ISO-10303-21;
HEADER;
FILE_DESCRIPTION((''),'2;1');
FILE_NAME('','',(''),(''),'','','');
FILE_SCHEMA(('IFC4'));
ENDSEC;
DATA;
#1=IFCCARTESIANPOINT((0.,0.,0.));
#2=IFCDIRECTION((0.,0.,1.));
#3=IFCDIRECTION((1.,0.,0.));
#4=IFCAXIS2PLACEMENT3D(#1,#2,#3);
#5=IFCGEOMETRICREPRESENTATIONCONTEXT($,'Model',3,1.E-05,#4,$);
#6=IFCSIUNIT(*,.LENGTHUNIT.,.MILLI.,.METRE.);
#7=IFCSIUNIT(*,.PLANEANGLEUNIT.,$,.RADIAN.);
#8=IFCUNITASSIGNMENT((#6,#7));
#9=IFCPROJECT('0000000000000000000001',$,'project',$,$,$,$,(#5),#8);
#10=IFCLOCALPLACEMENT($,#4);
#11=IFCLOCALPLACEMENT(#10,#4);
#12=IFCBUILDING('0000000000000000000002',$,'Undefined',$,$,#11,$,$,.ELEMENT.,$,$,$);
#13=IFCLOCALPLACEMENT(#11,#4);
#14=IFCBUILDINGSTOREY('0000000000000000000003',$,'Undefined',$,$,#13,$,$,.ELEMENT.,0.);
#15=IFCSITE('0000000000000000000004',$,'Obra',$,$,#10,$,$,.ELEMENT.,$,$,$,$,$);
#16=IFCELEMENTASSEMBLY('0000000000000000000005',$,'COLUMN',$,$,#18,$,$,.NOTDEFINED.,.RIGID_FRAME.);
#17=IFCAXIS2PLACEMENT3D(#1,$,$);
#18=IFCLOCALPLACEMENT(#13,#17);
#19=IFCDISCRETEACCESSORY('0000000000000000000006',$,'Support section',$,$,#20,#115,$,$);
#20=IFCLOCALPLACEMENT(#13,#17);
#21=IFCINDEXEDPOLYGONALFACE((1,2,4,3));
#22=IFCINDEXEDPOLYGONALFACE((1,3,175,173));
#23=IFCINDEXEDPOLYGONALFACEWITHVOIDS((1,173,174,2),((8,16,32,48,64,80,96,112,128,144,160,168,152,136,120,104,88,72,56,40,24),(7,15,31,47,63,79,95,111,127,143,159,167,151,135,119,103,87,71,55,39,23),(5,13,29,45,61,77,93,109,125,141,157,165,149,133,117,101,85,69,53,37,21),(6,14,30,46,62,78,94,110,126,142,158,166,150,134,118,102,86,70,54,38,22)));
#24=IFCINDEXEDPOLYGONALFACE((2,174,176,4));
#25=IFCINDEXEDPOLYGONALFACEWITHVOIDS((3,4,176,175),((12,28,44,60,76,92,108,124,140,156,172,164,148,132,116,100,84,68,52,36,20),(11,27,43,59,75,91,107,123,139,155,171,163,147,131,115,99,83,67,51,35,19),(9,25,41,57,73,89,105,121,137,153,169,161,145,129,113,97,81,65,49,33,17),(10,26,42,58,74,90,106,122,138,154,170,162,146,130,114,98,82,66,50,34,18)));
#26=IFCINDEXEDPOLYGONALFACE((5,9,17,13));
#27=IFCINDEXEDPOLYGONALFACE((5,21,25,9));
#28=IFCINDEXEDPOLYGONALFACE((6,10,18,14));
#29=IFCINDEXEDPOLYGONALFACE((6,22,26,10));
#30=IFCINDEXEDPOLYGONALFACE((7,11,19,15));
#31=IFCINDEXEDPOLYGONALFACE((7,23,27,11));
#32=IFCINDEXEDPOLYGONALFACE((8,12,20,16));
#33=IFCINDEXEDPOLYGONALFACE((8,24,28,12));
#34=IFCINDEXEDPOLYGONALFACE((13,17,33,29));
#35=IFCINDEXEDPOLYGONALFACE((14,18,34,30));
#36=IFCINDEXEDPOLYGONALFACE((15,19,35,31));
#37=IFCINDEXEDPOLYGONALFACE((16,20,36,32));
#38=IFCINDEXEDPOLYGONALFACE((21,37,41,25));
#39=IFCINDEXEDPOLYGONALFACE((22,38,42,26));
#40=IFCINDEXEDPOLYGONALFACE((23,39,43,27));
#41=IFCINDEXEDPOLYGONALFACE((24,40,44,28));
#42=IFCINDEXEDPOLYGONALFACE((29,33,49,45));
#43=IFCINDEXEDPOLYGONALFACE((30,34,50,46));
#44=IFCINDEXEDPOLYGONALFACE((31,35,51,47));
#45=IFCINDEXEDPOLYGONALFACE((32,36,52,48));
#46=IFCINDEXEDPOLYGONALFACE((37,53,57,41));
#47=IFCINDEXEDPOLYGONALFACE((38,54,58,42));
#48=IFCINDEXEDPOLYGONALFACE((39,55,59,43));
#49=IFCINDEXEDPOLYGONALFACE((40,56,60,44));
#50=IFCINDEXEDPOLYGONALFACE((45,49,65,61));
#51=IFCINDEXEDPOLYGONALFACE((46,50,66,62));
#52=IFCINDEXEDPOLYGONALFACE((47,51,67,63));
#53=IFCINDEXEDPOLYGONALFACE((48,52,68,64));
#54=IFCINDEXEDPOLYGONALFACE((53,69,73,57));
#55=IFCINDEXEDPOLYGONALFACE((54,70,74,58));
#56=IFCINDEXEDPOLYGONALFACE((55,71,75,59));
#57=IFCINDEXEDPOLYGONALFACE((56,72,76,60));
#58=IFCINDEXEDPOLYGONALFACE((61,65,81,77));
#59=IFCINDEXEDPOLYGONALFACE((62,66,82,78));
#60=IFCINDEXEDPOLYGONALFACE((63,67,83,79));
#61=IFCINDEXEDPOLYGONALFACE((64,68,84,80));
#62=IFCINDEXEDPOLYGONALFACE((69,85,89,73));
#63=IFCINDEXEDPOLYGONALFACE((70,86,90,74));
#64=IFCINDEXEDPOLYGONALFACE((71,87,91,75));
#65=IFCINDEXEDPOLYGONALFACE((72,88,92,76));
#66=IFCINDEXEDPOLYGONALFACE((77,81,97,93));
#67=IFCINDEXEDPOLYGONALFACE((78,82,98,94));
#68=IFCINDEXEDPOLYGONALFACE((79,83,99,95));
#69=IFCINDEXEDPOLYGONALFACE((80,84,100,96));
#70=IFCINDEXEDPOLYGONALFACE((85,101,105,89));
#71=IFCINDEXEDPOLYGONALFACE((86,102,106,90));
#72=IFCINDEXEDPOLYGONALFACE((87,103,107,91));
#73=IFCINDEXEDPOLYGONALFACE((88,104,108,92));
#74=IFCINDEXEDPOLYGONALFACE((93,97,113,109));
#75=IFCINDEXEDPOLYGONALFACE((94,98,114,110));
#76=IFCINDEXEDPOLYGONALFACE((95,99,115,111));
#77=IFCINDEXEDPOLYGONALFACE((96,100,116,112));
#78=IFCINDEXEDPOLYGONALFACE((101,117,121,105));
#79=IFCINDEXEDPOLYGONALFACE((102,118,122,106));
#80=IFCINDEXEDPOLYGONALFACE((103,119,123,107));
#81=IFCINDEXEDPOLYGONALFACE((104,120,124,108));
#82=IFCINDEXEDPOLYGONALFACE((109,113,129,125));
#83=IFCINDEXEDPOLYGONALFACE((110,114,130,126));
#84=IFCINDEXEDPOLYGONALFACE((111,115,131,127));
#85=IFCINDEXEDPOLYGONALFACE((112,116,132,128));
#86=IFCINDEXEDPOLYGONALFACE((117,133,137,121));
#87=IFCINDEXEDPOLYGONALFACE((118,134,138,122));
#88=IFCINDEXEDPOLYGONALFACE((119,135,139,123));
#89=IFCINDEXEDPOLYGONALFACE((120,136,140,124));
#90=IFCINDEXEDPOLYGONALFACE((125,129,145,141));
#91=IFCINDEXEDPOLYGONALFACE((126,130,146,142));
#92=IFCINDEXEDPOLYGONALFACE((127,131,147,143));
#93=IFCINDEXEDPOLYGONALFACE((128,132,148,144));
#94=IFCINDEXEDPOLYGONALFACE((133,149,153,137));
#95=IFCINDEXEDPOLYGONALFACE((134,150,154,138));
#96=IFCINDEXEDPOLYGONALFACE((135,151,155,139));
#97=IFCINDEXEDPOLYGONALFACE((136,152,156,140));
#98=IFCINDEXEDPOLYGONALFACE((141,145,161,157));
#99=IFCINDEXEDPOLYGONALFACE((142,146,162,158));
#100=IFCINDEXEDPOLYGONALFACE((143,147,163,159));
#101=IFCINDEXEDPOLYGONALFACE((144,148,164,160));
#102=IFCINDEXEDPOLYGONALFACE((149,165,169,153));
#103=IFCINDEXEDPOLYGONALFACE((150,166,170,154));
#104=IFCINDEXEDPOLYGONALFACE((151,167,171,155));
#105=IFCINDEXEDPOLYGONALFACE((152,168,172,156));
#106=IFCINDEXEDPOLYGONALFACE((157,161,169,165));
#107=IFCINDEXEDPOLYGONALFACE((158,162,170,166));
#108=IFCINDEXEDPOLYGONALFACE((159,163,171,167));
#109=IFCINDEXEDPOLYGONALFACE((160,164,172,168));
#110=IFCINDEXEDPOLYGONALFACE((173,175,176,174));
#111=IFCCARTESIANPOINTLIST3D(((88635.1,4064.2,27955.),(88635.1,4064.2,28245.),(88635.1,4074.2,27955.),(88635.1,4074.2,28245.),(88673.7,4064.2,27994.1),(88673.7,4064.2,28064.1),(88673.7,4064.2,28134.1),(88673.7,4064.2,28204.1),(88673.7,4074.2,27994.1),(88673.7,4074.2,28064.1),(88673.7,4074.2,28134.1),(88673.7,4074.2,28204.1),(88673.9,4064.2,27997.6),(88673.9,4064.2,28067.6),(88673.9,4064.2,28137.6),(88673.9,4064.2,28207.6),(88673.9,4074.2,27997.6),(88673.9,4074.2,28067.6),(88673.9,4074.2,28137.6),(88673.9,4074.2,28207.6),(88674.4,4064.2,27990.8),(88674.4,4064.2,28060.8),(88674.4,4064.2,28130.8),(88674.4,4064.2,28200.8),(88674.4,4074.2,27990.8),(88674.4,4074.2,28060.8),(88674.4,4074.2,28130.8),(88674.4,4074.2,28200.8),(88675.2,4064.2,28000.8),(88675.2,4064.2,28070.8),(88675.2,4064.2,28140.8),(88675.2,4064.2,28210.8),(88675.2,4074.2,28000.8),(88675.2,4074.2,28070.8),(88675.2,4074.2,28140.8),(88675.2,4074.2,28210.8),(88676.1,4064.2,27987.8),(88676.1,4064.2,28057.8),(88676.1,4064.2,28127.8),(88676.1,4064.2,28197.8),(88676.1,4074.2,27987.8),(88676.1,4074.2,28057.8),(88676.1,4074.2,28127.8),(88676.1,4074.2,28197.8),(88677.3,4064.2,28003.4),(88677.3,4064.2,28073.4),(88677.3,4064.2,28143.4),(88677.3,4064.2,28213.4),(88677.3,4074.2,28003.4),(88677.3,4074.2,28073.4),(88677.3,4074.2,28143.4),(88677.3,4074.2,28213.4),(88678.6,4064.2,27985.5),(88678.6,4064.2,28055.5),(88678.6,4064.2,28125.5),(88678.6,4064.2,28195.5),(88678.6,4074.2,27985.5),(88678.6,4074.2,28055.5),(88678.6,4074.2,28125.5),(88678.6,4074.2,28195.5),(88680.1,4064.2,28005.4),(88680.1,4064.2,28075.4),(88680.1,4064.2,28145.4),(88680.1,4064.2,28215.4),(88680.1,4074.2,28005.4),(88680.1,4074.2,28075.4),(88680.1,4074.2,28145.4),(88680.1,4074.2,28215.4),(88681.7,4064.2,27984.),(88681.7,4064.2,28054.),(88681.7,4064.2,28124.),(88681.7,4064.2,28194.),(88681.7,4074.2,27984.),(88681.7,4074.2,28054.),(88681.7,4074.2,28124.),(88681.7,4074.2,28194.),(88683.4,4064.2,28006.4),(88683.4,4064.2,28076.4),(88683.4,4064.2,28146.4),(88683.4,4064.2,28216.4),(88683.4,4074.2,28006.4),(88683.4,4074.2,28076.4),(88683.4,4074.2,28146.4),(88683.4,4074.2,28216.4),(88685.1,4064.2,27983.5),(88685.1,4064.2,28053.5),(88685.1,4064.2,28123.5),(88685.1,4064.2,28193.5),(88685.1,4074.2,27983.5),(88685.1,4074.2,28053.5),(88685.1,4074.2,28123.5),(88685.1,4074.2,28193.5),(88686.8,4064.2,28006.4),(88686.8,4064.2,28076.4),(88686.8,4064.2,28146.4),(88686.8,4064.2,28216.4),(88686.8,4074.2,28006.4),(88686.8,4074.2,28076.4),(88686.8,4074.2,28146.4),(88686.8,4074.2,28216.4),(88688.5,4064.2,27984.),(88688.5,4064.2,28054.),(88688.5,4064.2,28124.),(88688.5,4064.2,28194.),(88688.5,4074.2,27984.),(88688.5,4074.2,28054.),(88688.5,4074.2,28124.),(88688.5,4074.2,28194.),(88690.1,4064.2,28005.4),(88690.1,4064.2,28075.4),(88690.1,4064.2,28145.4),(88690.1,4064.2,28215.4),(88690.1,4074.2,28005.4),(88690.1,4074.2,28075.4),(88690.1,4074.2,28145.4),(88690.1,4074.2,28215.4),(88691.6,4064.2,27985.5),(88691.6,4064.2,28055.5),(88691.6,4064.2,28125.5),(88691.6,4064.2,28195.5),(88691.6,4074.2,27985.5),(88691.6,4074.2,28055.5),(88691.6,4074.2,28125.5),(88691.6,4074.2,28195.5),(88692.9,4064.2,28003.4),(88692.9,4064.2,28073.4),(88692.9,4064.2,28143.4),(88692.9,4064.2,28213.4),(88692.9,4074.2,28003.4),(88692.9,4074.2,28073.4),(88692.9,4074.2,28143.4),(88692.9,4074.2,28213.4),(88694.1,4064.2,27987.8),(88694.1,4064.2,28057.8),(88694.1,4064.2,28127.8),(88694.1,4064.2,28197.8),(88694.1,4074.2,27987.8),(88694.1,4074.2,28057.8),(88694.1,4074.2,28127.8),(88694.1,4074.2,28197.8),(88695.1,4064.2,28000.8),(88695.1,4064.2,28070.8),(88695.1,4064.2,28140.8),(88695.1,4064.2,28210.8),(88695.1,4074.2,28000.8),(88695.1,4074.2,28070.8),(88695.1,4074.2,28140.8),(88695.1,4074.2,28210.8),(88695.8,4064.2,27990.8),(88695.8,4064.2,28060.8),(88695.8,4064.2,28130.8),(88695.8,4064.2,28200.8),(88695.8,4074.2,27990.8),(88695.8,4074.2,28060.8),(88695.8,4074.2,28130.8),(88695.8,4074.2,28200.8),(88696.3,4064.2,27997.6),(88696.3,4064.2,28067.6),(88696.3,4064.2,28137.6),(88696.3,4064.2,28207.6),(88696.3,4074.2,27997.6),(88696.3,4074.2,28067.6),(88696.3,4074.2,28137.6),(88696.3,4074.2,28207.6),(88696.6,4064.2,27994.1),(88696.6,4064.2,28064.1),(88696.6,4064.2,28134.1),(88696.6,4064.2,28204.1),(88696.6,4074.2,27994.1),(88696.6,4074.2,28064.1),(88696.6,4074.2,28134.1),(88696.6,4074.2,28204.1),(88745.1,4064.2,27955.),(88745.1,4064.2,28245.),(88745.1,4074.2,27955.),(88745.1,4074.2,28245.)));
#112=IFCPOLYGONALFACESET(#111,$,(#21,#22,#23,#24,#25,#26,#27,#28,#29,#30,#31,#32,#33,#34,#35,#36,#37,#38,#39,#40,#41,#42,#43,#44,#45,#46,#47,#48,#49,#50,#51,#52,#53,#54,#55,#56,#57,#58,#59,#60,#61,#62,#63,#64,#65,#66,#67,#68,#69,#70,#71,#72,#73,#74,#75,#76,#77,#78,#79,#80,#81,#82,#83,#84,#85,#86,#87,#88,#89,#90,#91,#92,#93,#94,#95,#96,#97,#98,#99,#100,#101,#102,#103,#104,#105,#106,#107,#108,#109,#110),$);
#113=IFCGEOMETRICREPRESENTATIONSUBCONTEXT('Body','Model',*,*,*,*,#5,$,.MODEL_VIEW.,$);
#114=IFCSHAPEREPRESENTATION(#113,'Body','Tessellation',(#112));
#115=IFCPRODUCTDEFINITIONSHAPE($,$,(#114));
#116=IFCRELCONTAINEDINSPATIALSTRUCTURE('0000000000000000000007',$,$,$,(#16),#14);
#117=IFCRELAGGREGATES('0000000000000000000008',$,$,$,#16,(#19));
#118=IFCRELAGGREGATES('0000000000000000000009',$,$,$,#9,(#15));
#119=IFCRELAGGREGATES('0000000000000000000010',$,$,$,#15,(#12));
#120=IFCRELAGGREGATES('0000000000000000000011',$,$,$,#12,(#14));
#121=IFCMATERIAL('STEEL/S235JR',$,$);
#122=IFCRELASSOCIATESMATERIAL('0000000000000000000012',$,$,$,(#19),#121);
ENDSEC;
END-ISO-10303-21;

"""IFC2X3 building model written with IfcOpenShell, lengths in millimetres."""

from ifc_helpers import new_model, si_unit, frame, origin_with_axes, origin_2d_with_axis, place, context, subcontext, project, spatial, rectangle, circle, extrude, source, transform, mapped, material, element, aggregate, save


model = new_model("IFC2X3")

# Units and contexts
model_context = context("Model", 3, precision=1e-05, world=origin_with_axes())
body_context = subcontext(model_context, "Body", "Model", "MODEL_VIEW")
ifc_project = project(units=[si_unit("LENGTHUNIT", "METRE", prefix="MILLI"), si_unit("PLANEANGLEUNIT", "RADIAN")], contexts=[model_context])

# Site, building, storey
site_placement = place(None, origin_with_axes())
site = spatial("IfcSite", under=ifc_project, at=site_placement, Name="Obra", CompositionType="ELEMENT")
building_placement = place(site_placement, origin_with_axes())
building = spatial("IfcBuilding", under=site, at=building_placement, Name="Undefined", CompositionType="ELEMENT")
storey_placement = place(building_placement, origin_with_axes())
storey = spatial("IfcBuildingStorey", under=building, at=storey_placement, Name="Undefined", CompositionType="ELEMENT", Elevation=0.0)

# Element assembly
assembly_1_placement = place(storey_placement, origin_with_axes())
assembly_1 = element("IfcElementAssembly", 1, at=assembly_1_placement, inside=storey, Name="COLUMN", AssemblyPlace="NOTDEFINED", PredefinedType="RIGID_FRAME")
ifc_material = material(Name="STEEL/S235JR")

# Discrete accessory, opening
shared_shape_1 = source(origin_with_axes(), body_context, "Body", "SweptSolid", [
    extrude(circle(Radius=11.5, at=origin_2d_with_axis()), frame((0.0, -14.4, 0.0), z_axis=(0.0, 1.0, 0.0), x_axis=(1.0, 0.0, 0.0)), (0.0, 0.0, 1.0), 10.2),
])
discrete_accessory_1_placement = place(assembly_1_placement, frame((88690.1, 4069.2, 27955.0), z_axis=(0.0, 0.0, 1.0), x_axis=(1.0, 0.0, 0.0)))
discrete_accessory_1 = element("IfcDiscreteAccessory", 2, at=discrete_accessory_1_placement, material=ifc_material, Name="Support section", context=body_context, shape_type="SweptSolid", body=[
    extrude(rectangle(XDim=10.0, YDim=110.0, at=origin_2d_with_axis()), frame((0.0, 0.0, 290.0), z_axis=(0.0, 0.0, -1.0), x_axis=(0.0, 1.0, 0.0)), (0.0, 0.0, 1.0), 290.0),
])
opening_1_placement = place(assembly_1_placement, frame((88735.1, 4059.9, 28300.0), z_axis=(-1.0, 0.0, 0.0), x_axis=(0.0, 0.0, -1.0)))
element("IfcOpeningElement", 3, at=opening_1_placement, cuts=discrete_accessory_1, ObjectType="Opening", context=body_context, shape_type="MappedRepresentation", body=[
    mapped(shared_shape_1, transform((95.0, 0.0, 50.0))),
    mapped(shared_shape_1, transform((165.0, 0.0, 50.0))),
    mapped(shared_shape_1, transform((235.0, 0.0, 50.0))),
    mapped(shared_shape_1, transform((305.0, 0.0, 50.0))),
])
aggregate(assembly_1, [discrete_accessory_1])

save(model, "model.ifc")
